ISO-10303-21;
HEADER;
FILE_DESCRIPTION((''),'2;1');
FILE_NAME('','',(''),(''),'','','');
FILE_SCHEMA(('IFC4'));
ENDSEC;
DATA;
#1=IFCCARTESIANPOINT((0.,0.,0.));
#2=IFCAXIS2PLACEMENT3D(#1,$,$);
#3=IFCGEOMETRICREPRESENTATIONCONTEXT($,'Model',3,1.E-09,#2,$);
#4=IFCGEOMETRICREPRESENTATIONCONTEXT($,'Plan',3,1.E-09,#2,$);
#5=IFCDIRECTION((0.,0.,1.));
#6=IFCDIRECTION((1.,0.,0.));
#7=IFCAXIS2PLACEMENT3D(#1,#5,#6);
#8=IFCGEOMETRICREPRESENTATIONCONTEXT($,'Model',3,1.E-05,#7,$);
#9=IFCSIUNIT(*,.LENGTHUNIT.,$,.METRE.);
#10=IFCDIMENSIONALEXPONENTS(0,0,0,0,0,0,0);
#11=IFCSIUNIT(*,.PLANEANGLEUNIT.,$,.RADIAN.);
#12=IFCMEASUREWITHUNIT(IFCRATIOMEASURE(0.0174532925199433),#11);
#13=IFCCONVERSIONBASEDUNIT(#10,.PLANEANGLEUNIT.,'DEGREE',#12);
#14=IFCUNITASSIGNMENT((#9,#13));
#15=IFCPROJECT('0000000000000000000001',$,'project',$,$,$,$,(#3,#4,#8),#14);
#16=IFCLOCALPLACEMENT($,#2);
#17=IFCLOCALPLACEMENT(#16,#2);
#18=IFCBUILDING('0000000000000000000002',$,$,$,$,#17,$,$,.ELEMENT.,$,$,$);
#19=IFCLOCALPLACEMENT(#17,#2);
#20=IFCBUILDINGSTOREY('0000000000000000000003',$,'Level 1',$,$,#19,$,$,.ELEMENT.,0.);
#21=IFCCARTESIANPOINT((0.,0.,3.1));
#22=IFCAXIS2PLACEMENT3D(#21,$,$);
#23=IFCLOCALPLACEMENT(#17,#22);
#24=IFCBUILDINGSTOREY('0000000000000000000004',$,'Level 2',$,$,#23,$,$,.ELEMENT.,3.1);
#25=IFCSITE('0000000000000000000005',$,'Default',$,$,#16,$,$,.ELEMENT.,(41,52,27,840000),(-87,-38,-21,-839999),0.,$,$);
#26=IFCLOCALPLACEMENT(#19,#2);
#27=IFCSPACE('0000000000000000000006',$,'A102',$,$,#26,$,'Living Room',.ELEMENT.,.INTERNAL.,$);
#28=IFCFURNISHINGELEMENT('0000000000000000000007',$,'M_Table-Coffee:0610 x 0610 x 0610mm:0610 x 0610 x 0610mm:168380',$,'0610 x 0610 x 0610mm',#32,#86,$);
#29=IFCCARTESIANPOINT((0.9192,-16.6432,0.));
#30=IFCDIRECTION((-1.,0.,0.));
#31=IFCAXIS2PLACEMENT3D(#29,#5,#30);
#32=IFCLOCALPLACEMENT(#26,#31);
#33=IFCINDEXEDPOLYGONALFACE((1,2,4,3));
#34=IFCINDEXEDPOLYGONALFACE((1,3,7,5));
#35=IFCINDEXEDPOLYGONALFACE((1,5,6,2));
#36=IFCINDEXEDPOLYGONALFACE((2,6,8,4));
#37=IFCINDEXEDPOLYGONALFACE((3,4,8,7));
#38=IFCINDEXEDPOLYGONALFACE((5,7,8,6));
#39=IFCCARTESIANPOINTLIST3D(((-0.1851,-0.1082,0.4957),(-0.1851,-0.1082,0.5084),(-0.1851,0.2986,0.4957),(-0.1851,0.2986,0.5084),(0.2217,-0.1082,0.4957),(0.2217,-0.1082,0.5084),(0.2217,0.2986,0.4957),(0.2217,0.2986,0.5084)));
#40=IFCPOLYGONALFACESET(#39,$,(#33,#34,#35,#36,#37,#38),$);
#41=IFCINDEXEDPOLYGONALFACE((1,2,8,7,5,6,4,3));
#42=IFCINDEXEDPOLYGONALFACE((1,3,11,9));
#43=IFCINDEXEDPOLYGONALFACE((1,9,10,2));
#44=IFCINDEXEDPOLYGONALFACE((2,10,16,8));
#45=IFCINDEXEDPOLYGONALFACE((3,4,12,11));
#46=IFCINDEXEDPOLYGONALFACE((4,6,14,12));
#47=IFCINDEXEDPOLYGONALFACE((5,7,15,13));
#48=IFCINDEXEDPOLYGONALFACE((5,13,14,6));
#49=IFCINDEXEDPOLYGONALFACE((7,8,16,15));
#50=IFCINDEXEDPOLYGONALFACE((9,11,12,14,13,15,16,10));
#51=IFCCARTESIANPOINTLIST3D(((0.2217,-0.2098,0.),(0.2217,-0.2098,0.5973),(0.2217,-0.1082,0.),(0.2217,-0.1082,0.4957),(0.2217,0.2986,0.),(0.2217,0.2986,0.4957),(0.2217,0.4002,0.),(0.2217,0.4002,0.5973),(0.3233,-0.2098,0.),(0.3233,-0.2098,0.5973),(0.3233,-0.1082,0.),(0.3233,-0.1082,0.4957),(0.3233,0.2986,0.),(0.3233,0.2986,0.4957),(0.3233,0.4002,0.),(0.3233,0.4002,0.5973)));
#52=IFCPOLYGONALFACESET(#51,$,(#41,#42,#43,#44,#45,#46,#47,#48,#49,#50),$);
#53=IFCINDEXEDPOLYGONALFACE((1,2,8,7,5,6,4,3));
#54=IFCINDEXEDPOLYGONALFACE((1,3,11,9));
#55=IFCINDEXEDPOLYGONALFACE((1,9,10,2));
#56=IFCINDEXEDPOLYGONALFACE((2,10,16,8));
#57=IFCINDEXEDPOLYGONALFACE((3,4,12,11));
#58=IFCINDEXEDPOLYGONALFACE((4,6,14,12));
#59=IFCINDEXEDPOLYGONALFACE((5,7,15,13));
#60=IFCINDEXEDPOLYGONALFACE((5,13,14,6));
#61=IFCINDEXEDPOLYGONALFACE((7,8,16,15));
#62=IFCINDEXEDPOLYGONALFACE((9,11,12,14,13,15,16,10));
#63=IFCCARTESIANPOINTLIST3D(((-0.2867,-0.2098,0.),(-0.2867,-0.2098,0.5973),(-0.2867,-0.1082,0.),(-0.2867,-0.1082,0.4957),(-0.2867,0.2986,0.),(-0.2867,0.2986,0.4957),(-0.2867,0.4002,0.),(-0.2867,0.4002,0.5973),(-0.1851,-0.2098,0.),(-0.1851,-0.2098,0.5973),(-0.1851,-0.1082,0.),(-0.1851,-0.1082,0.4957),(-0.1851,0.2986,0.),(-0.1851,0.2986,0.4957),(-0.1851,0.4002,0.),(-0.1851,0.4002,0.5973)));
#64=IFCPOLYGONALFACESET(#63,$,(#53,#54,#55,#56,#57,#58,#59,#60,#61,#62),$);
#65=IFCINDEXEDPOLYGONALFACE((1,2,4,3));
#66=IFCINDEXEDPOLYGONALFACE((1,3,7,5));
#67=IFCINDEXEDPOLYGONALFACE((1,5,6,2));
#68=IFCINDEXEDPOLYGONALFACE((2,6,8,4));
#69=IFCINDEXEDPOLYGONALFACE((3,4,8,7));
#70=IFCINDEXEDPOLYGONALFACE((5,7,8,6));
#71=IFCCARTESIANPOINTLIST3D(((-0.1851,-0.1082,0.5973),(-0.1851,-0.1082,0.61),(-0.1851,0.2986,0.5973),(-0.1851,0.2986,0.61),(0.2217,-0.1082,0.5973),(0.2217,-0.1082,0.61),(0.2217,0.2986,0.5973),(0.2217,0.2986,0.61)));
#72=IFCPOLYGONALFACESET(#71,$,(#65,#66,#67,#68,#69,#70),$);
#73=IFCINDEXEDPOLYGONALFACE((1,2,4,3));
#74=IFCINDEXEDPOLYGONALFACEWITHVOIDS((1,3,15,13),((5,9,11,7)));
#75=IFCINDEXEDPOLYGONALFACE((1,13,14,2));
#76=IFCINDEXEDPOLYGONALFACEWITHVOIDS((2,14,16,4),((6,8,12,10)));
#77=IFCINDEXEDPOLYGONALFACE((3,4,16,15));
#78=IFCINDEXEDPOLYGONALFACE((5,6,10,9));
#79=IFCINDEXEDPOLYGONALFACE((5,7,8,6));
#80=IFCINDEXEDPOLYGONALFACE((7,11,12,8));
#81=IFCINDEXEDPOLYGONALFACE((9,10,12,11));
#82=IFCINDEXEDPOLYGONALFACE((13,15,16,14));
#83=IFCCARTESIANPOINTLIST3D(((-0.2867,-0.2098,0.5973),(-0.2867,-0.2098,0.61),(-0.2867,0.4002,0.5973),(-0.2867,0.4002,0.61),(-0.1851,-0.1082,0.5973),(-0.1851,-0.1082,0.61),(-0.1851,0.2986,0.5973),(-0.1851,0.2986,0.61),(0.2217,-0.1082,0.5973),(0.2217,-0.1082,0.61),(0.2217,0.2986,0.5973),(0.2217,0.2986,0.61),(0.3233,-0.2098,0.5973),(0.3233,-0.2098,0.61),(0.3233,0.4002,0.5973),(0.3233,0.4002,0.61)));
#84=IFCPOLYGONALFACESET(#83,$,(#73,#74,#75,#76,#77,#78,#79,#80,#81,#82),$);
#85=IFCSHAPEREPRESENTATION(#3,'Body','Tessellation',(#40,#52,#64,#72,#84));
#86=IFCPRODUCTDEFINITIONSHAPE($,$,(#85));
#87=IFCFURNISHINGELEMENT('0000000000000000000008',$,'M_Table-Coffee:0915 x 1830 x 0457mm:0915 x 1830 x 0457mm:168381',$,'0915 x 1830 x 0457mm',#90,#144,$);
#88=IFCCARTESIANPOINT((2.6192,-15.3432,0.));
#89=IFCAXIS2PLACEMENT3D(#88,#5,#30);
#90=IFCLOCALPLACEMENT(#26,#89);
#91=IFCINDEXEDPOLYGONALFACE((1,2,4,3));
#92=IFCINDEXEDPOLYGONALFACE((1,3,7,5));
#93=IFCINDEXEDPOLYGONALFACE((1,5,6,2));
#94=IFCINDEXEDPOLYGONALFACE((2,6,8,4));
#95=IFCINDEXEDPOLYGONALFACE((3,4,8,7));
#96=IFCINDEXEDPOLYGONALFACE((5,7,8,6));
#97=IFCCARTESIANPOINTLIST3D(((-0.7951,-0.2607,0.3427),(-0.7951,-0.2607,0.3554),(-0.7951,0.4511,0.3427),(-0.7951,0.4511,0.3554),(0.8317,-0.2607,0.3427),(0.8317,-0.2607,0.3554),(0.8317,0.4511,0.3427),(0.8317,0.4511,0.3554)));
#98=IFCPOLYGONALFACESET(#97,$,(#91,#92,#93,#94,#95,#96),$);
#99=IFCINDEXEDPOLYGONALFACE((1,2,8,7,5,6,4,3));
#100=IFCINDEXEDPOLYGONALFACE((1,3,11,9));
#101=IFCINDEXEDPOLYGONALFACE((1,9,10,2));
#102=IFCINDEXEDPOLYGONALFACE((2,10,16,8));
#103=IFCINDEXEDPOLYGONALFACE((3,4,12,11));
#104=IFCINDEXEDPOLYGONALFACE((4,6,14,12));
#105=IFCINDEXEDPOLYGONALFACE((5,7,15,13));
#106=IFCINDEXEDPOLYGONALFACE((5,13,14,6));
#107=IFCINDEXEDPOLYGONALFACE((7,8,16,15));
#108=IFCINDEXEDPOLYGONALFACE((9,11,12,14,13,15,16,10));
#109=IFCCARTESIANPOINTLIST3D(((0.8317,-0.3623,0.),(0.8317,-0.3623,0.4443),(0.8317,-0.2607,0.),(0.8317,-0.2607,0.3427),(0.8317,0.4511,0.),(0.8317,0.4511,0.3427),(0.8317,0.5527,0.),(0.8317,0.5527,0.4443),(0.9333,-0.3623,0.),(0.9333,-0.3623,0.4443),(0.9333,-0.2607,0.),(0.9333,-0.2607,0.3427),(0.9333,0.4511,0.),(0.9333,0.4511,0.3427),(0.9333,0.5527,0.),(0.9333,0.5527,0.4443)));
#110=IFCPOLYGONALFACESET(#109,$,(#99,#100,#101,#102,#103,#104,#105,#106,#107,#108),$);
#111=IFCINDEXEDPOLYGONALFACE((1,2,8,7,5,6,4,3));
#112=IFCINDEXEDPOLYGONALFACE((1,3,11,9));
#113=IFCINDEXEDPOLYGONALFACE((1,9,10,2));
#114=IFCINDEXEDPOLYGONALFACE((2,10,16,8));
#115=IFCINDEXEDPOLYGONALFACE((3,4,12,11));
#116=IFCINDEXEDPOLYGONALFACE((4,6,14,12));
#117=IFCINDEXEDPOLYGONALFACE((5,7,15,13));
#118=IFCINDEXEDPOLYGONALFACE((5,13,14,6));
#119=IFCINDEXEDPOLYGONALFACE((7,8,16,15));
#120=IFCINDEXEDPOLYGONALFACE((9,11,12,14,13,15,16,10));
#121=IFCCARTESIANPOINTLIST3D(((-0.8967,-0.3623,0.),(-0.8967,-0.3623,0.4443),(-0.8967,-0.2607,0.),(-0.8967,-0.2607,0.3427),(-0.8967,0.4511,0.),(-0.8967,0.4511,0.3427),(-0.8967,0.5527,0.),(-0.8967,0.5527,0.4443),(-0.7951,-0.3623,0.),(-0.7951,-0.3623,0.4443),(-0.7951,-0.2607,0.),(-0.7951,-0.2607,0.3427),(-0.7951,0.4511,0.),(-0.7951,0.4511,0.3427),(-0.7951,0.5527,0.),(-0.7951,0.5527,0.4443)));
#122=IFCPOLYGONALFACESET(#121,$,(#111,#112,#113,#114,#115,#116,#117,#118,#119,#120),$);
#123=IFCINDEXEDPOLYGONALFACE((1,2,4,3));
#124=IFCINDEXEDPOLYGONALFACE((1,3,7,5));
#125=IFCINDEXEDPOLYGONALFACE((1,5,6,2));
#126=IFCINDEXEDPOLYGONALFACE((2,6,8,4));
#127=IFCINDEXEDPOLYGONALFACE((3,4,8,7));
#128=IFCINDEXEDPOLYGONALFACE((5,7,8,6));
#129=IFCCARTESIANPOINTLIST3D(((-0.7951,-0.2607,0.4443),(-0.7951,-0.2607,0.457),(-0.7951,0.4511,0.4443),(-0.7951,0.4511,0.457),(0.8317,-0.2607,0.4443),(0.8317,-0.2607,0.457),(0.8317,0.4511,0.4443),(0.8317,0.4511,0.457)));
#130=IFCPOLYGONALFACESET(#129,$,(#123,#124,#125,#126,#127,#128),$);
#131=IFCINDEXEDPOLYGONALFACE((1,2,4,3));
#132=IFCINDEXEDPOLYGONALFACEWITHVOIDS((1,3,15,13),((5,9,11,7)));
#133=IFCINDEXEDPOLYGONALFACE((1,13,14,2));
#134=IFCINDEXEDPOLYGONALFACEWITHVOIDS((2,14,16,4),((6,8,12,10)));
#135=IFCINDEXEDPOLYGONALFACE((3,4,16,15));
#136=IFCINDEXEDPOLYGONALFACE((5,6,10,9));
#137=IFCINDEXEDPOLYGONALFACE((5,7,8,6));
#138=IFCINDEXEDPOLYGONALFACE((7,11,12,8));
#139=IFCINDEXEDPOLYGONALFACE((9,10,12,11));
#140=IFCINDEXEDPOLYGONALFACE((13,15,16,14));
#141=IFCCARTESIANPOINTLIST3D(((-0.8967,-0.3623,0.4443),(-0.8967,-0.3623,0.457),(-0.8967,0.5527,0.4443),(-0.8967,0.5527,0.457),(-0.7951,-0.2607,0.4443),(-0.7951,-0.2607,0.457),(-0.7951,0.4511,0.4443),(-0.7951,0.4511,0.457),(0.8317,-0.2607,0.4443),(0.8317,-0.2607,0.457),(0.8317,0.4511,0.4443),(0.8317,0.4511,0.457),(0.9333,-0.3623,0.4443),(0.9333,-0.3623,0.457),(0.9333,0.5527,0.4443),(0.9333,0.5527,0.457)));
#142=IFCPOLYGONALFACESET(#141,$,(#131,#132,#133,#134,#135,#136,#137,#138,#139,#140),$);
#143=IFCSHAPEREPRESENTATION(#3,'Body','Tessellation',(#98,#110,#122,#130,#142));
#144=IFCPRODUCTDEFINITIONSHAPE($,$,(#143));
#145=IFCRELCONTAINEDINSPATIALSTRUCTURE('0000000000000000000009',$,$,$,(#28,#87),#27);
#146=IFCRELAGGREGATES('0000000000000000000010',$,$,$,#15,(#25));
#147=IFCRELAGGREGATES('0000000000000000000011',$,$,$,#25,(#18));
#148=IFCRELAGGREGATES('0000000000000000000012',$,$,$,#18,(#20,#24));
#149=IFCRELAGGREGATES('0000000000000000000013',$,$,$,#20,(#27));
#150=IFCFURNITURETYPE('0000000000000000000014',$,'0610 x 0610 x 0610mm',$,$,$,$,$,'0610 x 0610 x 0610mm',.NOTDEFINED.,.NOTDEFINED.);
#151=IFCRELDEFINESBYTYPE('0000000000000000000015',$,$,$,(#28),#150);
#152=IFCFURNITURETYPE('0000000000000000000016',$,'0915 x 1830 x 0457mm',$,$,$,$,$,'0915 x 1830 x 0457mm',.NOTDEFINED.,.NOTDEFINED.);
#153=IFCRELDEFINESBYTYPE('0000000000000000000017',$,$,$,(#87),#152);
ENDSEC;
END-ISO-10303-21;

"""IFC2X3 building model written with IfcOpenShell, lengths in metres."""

from ifc_helpers import new_model, entity, si_unit, converted_unit, frame, origin, origin_with_axes, origin_2d_with_axis, place, context, project, spatial, polyline, rectangle, outline, extrude, source, transform, mapped, type_object, type_shapes, element, save


model = new_model("IFC2X3")

# Units and contexts
model_context_1 = context("Model", 3, precision=1e-09, world=origin())
plan_context = context("Plan", 3, precision=1e-09, world=origin())
model_context_2 = context("Model", 3, precision=1e-05, world=origin_with_axes())
ifc_project = project(units=[si_unit("LENGTHUNIT", "METRE"), converted_unit("PLANEANGLEUNIT", "DEGREE", entity("IfcRatioMeasure", 0.0174532925199433), si_unit("PLANEANGLEUNIT", "RADIAN"), dimensions=[0, 0, 0, 0, 0, 0, 0])], contexts=[model_context_1, plan_context, model_context_2])

# Site, building, storey
site_placement = place(None, origin())
site = spatial("IfcSite", under=ifc_project, at=site_placement, Name="Default", CompositionType="ELEMENT", RefLatitude=(41, 52, 27, 840000), RefLongitude=(-87, -38, -21, -839999), RefElevation=0.0)
building_placement = place(site_placement, origin())
building = spatial("IfcBuilding", under=site, at=building_placement, CompositionType="ELEMENT")
storey_1_placement = place(building_placement, origin())
storey_1 = spatial("IfcBuildingStorey", under=building, at=storey_1_placement, Name="Level 1", CompositionType="ELEMENT", Elevation=0.0)

# Shared definitions
storey_2_placement = place(building_placement, frame((0.0, 0.0, 3.1)))
storey_2 = spatial("IfcBuildingStorey", under=building, at=storey_2_placement, Name="Level 2", CompositionType="ELEMENT", Elevation=3.1)

# Shared definitions
space_1_placement = place(storey_1_placement, origin())
space_1 = spatial("IfcSpace", under=storey_1, at=space_1_placement, Name="A102", LongName="Living Room", CompositionType="ELEMENT", InteriorOrExteriorSpace="INTERNAL")

# Furnishing elements
furniture_type_1 = type_object("IfcFurnitureType", Name="0610 x 0610 x 0610mm", ElementType="0610 x 0610 x 0610mm", AssemblyPlace="NOTDEFINED")
shared_shape_1 = source(origin(), model_context_1, "Body", "SweptSolid", [
    extrude(rectangle(XDim=0.4068, YDim=0.4068, at=origin_2d_with_axis()), frame((0.0183, 0.0952, 0.4957), z_axis=(0.0, 0.0, 1.0), x_axis=(-1.0, 0.0, 0.0)), (0.0, 0.0, 1.0), 0.0127),
    extrude(outline(polyline([(-0.2732, -0.305), (0.324, -0.305), (0.324, 0.305), (-0.2732, 0.305), (-0.2732, 0.2034), (0.2225, 0.2034), (0.2225, -0.2034), (-0.2732, -0.2034), (-0.2732, -0.305)])), frame((0.2217, 0.0952, 0.2732), z_axis=(1.0, 0.0, 0.0), x_axis=(0.0, 0.0, 1.0)), (0.0, 0.0, 1.0), 0.1016),
    extrude(outline(polyline([(-0.305, -0.3241), (0.305, -0.3241), (0.305, 0.2733), (0.2034, 0.2733), (0.2034, -0.2224), (-0.2034, -0.2224), (-0.2034, 0.2733), (-0.305, 0.2733), (-0.305, -0.3241)])), frame((-0.2867, 0.0952, 0.2733), z_axis=(1.0, 0.0, 0.0), x_axis=(0.0, -1.0, 0.0)), (0.0, 0.0, 1.0), 0.1016),
    extrude(rectangle(XDim=0.4068, YDim=0.4068, at=origin_2d_with_axis()), frame((0.0183, 0.0952, 0.5973), z_axis=(0.0, 0.0, 1.0), x_axis=(-1.0, 0.0, 0.0)), (0.0, 0.0, 1.0), 0.0127),
    extrude(outline(polyline([(-0.305, -0.305), (0.305, -0.305), (0.305, 0.305), (-0.305, 0.305), (-0.305, -0.305)]), holes=[polyline([(-0.2034, -0.2034), (-0.2034, 0.2034), (0.2034, 0.2034), (0.2034, -0.2034), (-0.2034, -0.2034)])]), frame((0.0183, 0.0952, 0.5973), z_axis=(0.0, 0.0, 1.0), x_axis=(-1.0, 0.0, 0.0)), (0.0, 0.0, 1.0), 0.0127),
])
type_shapes(furniture_type_1, [shared_shape_1])
for number, where, z_axis, x_axis, name in (
    (1, (0.9192, -16.6432, 0.0), (0.0, 0.0, 1.0), (-1.0, 0.0, 0.0), "M_Table-Coffee:0610 x 0610 x 0610mm:0610 x 0610 x 0610mm:168380"),
):
    element("IfcFurnishingElement", number, at=place(space_1_placement, frame(where, z_axis=z_axis, x_axis=x_axis)), inside=space_1, type_object=furniture_type_1, Name=name, ObjectType="0610 x 0610 x 0610mm", context=model_context_1, shape_type="MappedRepresentation", body=[
        mapped(shared_shape_1, transform((0.0, 0.0, 0.0), scale=1.0)),
    ])
furniture_type_2 = type_object("IfcFurnitureType", Name="0915 x 1830 x 0457mm", ElementType="0915 x 1830 x 0457mm", AssemblyPlace="NOTDEFINED")
shared_shape_2 = source(origin(), model_context_1, "Body", "SweptSolid", [
    extrude(rectangle(XDim=1.6268, YDim=0.7118, at=origin_2d_with_axis()), frame((0.0183, 0.0952, 0.3427), z_axis=(0.0, 0.0, 1.0), x_axis=(-1.0, 0.0, 0.0)), (0.0, 0.0, 1.0), 0.0127),
    extrude(outline(polyline([(-0.1967, -0.4575), (0.2475, -0.4575), (0.2475, 0.4575), (-0.1967, 0.4575), (-0.1967, 0.3559), (0.146, 0.3559), (0.146, -0.3559), (-0.1967, -0.3559), (-0.1967, -0.4575)])), frame((0.8317, 0.0952, 0.1967), z_axis=(1.0, 0.0, 0.0), x_axis=(0.0, 0.0, 1.0)), (0.0, 0.0, 1.0), 0.1016),
    extrude(outline(polyline([(-0.4575, -0.2476), (0.4575, -0.2476), (0.4575, 0.1968), (0.3559, 0.1968), (0.3559, -0.1459), (-0.3559, -0.1459), (-0.3559, 0.1968), (-0.4575, 0.1968), (-0.4575, -0.2476)])), frame((-0.8967, 0.0952, 0.1968), z_axis=(1.0, 0.0, 0.0), x_axis=(0.0, -1.0, 0.0)), (0.0, 0.0, 1.0), 0.1016),
    extrude(rectangle(XDim=1.6268, YDim=0.7118, at=origin_2d_with_axis()), frame((0.0183, 0.0952, 0.4443), z_axis=(0.0, 0.0, 1.0), x_axis=(-1.0, 0.0, 0.0)), (0.0, 0.0, 1.0), 0.0127),
    extrude(outline(polyline([(-0.915, -0.4575), (0.915, -0.4575), (0.915, 0.4575), (-0.915, 0.4575), (-0.915, -0.4575)]), holes=[polyline([(-0.8134, -0.3559), (-0.8134, 0.3559), (0.8134, 0.3559), (0.8134, -0.3559), (-0.8134, -0.3559)])]), frame((0.0183, 0.0952, 0.4443), z_axis=(0.0, 0.0, 1.0), x_axis=(-1.0, 0.0, 0.0)), (0.0, 0.0, 1.0), 0.0127),
])
type_shapes(furniture_type_2, [shared_shape_2])
furnishing_1_placement = place(space_1_placement, frame((2.6192, -15.3432, 0.0), z_axis=(0.0, 0.0, 1.0), x_axis=(-1.0, 0.0, 0.0)))
element("IfcFurnishingElement", 2, at=furnishing_1_placement, inside=space_1, type_object=furniture_type_2, Name="M_Table-Coffee:0915 x 1830 x 0457mm:0915 x 1830 x 0457mm:168381", ObjectType="0915 x 1830 x 0457mm", context=model_context_1, shape_type="MappedRepresentation", body=[
    mapped(shared_shape_2, transform((0.0, 0.0, 0.0), scale=1.0)),
])

save(model, "model.ifc")
